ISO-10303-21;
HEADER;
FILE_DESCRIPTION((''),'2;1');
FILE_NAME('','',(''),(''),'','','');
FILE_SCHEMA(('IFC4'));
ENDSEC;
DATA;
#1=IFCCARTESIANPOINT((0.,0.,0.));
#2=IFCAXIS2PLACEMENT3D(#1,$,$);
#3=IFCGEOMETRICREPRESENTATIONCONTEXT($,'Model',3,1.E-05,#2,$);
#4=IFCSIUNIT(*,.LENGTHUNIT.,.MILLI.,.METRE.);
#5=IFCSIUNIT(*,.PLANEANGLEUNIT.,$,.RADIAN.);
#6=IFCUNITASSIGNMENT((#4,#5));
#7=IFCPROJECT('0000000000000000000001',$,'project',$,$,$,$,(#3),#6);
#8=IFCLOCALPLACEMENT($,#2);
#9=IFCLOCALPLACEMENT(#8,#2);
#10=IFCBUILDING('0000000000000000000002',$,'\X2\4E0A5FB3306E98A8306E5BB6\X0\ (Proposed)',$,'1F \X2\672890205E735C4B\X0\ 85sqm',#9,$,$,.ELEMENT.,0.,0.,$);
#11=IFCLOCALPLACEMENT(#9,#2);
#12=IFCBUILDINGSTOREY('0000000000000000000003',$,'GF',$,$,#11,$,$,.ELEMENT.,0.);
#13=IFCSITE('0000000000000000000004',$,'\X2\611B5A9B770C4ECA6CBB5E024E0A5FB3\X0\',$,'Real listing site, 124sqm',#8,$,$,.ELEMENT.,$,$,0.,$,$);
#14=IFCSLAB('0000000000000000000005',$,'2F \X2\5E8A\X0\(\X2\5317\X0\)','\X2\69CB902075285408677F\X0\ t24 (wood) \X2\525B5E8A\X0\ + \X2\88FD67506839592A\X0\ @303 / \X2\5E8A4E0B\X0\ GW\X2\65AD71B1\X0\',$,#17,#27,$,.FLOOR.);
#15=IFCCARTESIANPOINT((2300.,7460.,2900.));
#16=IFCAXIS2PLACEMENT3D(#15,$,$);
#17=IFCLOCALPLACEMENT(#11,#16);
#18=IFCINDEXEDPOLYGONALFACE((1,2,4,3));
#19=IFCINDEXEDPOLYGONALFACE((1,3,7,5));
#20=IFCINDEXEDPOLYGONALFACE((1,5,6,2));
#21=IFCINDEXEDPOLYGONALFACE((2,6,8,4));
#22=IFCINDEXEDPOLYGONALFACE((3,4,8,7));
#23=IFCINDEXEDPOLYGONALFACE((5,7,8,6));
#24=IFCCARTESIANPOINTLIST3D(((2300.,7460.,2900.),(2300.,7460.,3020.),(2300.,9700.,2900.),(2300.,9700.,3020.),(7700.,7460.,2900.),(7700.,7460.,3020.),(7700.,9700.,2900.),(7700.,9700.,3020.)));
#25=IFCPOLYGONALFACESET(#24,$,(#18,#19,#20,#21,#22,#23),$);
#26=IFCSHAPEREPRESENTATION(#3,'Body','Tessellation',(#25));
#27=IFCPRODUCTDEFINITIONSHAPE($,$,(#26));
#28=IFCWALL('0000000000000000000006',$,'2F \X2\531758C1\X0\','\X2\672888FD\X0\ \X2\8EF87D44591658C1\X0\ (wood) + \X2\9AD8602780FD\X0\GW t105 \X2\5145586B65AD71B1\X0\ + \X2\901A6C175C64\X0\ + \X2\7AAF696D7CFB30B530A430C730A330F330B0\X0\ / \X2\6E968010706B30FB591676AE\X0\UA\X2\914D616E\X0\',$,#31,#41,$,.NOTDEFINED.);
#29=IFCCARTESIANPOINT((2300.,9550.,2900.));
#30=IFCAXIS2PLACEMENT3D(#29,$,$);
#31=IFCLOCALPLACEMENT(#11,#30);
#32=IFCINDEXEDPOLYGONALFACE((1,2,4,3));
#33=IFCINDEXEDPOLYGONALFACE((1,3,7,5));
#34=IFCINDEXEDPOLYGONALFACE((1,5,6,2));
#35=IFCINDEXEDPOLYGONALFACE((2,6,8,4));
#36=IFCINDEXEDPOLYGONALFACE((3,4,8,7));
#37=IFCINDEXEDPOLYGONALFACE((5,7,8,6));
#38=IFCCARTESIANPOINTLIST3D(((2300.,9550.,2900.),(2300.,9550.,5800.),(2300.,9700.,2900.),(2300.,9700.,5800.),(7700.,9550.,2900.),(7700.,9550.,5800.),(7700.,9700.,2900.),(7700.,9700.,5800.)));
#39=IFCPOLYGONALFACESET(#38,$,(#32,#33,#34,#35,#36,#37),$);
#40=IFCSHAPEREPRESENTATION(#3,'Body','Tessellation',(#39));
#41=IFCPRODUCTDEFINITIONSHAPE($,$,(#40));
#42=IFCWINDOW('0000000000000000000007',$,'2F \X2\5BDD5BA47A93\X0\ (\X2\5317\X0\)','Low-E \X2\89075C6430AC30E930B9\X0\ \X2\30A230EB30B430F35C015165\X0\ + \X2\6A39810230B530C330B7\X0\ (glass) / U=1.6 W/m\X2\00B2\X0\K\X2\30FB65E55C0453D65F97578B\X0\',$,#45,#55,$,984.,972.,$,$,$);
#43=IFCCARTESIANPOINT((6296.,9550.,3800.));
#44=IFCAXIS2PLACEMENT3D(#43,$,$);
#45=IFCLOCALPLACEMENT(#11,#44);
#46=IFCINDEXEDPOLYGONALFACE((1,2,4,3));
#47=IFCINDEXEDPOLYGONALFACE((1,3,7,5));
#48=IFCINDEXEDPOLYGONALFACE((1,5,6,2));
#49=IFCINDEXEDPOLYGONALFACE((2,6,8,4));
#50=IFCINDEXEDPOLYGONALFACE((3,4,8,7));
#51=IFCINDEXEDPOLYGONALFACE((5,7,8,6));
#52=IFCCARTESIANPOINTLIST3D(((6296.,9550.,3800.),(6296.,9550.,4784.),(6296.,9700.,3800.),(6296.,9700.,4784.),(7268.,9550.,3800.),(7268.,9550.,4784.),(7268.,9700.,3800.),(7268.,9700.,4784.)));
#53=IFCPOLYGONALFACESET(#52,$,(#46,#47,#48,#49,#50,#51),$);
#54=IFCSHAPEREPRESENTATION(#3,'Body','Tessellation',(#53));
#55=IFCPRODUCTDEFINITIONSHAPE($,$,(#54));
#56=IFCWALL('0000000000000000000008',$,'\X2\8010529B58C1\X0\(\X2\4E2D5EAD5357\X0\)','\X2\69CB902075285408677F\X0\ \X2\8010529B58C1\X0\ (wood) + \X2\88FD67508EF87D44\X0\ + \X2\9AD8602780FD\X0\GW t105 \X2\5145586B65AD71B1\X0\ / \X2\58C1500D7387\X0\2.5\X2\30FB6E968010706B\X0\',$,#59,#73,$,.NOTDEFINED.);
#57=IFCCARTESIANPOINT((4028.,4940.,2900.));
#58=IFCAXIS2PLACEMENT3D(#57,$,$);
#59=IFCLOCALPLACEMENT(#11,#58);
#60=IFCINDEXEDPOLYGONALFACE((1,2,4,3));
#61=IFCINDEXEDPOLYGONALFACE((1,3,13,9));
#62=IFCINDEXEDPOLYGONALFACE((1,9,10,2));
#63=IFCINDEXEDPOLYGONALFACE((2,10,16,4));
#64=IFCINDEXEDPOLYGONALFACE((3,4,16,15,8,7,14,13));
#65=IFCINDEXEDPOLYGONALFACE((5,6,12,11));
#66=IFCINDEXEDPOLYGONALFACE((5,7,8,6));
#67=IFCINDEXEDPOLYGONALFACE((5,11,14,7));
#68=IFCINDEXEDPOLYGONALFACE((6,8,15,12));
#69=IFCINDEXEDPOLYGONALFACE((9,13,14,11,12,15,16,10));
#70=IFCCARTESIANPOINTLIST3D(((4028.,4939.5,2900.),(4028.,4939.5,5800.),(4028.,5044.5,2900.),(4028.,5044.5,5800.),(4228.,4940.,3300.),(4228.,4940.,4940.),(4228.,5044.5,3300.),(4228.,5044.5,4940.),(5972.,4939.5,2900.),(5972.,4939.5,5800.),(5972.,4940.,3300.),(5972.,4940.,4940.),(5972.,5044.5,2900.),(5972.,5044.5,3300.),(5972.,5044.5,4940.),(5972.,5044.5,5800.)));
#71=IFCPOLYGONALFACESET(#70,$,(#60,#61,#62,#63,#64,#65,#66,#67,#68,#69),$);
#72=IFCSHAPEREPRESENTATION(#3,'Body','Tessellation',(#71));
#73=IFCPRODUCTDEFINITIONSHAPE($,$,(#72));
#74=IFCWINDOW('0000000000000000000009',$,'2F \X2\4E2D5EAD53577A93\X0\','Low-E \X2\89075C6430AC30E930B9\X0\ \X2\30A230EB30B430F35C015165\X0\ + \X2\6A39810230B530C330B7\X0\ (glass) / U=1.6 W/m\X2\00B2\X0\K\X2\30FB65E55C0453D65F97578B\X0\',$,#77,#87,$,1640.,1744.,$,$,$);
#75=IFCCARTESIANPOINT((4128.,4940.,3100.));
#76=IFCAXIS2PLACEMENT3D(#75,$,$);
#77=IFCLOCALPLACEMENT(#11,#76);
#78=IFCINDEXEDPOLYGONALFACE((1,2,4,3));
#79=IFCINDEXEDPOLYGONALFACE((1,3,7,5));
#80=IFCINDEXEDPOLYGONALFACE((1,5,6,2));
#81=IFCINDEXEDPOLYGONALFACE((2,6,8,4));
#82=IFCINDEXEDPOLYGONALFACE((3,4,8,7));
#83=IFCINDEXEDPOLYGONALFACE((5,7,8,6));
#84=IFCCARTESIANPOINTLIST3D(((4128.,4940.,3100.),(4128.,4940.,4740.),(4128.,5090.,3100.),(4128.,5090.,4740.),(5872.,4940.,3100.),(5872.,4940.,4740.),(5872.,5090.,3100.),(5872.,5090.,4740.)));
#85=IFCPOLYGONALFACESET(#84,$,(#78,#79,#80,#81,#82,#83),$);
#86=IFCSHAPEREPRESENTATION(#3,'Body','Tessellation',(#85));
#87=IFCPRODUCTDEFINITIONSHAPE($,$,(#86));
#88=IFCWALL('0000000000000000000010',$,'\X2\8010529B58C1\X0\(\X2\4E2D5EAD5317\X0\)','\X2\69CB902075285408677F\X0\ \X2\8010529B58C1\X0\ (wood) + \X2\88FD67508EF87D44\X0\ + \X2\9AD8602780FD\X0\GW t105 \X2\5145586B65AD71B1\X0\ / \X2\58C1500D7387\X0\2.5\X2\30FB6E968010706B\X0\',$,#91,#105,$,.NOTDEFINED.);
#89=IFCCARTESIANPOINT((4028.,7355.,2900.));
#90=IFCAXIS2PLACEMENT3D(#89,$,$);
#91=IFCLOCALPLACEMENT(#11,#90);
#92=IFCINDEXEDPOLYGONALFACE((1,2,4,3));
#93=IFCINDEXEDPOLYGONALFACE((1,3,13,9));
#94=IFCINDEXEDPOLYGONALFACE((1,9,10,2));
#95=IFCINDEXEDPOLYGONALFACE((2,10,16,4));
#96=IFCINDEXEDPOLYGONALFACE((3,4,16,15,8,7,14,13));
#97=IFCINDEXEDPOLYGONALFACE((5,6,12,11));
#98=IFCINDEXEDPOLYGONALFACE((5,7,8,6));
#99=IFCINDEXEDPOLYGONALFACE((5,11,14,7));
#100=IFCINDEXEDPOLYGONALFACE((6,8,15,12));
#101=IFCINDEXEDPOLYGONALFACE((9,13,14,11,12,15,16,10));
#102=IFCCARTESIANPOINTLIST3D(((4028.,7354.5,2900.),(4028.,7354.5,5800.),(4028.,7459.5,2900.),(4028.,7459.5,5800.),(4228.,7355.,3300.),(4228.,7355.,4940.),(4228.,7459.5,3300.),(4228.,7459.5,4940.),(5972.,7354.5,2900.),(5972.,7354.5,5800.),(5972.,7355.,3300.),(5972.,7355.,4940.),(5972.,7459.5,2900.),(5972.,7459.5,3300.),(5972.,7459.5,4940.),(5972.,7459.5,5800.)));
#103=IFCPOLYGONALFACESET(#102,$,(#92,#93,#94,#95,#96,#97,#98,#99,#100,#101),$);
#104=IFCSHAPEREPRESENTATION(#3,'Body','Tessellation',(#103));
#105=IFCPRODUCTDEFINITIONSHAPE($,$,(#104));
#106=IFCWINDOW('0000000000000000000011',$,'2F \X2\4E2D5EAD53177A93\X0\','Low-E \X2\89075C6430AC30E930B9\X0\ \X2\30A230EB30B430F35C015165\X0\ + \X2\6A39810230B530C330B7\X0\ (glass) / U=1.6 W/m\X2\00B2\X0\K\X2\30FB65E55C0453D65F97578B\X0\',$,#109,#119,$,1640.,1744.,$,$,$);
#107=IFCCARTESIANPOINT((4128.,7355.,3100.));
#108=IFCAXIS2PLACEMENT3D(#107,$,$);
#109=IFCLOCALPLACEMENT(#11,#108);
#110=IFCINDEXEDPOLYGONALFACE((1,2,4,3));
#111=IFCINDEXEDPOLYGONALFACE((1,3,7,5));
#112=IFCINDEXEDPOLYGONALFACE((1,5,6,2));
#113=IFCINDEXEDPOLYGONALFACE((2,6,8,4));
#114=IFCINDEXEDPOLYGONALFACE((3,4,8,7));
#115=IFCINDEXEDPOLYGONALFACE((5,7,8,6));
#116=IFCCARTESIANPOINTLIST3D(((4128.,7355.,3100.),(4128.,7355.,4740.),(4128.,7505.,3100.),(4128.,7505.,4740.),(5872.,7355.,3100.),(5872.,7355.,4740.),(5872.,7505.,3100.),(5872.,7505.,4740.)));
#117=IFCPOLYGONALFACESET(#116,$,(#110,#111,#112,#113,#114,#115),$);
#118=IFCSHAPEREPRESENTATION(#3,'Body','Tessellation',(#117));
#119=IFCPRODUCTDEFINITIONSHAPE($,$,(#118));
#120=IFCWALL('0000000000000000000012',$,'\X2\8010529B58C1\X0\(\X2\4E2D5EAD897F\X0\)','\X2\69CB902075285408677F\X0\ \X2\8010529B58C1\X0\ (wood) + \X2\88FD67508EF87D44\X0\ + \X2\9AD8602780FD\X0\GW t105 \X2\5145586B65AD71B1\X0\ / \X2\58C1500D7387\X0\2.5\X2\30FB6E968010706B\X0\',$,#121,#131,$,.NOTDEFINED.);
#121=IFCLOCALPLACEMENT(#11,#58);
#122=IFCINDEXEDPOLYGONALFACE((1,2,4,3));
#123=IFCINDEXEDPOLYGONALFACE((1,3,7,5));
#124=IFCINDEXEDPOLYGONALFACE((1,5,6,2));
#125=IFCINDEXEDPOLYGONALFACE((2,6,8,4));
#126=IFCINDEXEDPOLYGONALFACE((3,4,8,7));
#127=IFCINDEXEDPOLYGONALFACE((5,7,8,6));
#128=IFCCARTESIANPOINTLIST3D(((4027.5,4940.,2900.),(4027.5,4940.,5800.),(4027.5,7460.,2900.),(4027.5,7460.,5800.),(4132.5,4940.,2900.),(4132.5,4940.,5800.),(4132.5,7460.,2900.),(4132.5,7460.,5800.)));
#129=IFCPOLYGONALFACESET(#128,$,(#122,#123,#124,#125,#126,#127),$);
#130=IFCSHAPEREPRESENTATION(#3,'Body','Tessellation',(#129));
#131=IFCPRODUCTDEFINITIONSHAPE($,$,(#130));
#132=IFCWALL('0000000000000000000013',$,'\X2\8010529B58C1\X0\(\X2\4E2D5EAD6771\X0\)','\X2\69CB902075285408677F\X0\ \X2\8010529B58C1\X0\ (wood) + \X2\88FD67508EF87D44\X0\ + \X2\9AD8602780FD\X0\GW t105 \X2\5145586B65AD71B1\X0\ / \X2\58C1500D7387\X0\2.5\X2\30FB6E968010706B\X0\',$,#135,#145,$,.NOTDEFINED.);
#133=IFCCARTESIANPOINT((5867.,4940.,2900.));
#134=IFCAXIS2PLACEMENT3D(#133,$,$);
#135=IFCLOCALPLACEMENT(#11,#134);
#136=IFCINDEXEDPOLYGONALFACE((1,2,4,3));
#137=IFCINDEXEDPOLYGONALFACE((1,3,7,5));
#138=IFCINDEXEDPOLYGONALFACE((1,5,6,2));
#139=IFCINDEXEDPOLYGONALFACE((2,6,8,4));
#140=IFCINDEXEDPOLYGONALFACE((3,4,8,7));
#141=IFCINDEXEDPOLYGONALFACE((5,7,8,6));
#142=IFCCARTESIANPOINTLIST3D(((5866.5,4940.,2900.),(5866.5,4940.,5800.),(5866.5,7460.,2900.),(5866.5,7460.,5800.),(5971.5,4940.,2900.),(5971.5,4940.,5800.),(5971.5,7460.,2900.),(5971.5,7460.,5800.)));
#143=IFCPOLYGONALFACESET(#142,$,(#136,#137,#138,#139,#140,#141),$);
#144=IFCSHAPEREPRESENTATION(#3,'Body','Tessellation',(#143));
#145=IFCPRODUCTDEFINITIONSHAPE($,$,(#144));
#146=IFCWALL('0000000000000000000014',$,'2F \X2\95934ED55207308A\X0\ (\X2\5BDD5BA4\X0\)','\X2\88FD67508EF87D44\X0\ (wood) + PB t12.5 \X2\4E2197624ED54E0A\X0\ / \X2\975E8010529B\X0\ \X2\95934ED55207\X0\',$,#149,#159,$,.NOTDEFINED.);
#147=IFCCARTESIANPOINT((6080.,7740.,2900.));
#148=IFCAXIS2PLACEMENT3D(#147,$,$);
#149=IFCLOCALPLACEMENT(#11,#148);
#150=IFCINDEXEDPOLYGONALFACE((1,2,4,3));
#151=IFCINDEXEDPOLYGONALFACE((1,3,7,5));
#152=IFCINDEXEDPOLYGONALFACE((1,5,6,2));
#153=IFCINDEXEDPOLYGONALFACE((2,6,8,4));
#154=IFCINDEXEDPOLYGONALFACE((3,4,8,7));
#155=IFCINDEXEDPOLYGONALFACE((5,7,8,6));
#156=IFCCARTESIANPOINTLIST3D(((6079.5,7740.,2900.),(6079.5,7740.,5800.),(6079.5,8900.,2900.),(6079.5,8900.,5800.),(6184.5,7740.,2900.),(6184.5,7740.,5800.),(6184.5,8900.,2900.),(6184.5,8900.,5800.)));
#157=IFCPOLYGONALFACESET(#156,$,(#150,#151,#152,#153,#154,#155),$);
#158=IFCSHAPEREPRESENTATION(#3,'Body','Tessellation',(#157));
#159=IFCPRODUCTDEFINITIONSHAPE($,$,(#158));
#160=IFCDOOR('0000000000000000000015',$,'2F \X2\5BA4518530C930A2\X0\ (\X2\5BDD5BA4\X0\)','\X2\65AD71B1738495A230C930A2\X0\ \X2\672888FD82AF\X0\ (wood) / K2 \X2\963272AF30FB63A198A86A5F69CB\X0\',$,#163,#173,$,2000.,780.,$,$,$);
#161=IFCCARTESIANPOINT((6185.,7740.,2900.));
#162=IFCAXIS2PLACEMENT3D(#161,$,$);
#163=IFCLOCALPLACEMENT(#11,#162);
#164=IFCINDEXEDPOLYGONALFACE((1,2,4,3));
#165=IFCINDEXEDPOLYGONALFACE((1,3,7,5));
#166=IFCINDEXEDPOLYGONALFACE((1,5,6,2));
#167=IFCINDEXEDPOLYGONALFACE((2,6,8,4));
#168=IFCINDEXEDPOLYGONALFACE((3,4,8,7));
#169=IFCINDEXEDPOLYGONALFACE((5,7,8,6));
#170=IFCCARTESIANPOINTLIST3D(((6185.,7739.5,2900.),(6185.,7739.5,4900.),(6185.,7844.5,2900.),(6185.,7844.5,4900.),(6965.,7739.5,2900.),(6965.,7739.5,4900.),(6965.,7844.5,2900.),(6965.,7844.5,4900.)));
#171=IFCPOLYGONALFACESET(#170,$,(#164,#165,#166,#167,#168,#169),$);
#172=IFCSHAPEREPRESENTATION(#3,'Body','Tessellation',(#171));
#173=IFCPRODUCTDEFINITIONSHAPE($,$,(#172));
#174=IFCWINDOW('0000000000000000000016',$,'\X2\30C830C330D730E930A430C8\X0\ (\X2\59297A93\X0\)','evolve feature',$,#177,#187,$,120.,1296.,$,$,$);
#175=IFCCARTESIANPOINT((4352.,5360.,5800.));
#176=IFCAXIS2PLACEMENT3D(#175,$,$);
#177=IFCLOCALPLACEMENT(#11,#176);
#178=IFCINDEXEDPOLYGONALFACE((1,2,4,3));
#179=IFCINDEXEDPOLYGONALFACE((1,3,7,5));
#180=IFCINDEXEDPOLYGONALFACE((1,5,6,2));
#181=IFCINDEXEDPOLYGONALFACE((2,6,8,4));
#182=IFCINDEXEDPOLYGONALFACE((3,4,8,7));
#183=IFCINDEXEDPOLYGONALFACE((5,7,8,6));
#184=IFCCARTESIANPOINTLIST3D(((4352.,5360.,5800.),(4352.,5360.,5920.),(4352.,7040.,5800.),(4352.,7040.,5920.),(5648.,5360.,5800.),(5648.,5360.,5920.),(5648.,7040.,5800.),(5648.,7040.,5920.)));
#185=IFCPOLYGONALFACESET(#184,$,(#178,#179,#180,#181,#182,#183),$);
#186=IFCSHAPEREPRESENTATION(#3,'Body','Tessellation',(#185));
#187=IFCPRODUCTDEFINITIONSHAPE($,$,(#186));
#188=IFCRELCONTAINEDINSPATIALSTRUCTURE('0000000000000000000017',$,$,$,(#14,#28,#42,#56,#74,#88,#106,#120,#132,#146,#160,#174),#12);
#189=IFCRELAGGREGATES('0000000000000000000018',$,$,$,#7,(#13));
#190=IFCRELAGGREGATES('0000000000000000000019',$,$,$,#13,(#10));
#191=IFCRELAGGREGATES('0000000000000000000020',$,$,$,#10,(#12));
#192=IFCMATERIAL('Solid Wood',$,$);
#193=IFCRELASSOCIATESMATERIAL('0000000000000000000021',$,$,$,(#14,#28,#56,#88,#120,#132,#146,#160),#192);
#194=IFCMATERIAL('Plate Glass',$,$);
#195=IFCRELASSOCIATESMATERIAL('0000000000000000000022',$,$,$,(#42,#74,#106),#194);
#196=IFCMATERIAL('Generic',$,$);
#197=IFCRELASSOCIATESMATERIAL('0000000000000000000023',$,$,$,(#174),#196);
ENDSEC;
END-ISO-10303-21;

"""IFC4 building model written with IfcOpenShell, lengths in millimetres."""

from ifc_helpers import new_model, si_unit, frame, frame_2d, origin, place, context, project, spatial, rectangle, extrude, material, element, fill, save


model = new_model("IFC4")

# Units and contexts
model_context = context("Model", 3, precision=1e-05, world=origin())
ifc_project = project(units=[si_unit("LENGTHUNIT", "METRE", prefix="MILLI"), si_unit("PLANEANGLEUNIT", "RADIAN")], contexts=[model_context])

# Site, building, storey
site_placement = place(None, origin())
site = spatial("IfcSite", under=ifc_project, at=site_placement, Name="愛媛県今治市上徳", ObjectType="Real listing site, 124sqm", CompositionType="ELEMENT", RefElevation=0.0)
building_placement = place(site_placement, origin())
building = spatial("IfcBuilding", under=site, at=building_placement, Name="上徳の風の家 (Proposed)", ObjectType="1F 木造平屋 85sqm", CompositionType="ELEMENT", ElevationOfRefHeight=0.0, ElevationOfTerrain=0.0)
storey_placement = place(building_placement, origin())
storey = spatial("IfcBuildingStorey", under=building, at=storey_placement, Name="GF", CompositionType="ELEMENT", Elevation=0.0)

# Slab
ifc_material_1 = material(Name="Solid Wood")
slab_placement = place(storey_placement, frame((2300.0, 7460.0, 2900.0)))
element("IfcSlab", 1, at=slab_placement, inside=storey, material=ifc_material_1, Name="2F 床(北)", Description="構造用合板 t24 (wood) 剛床 + 製材根太 @303 / 床下 GW断熱", PredefinedType="FLOOR", context=model_context, shape_type="SweptSolid", body=[
    extrude(rectangle(XDim=5400.0, YDim=2240.0, at=frame_2d((2700.0, 1120.0))), frame((2300.0, 7460.0, 2900.0)), (0.0, 0.0, 1.0), 120.0),
])

# Walls, openings, windows
wall_1_placement = place(storey_placement, frame((2300.0, 9550.0, 2900.0)))
wall_1 = element("IfcWall", 2, at=wall_1_placement, inside=storey, material=ifc_material_1, Name="2F 北壁", Description="木製 軸組外壁 (wood) + 高性能GW t105 充填断熱 + 通気層 + 窯業系サイディング / 準耐火・外皮UA配慮", PredefinedType="NOTDEFINED", context=model_context, shape_type="SweptSolid", body=[
    extrude(rectangle(XDim=5400.0, YDim=150.0, at=frame_2d((2700.0, 75.0))), frame((2300.0, 9550.0, 2900.0)), (0.0, 0.0, 1.0), 2900.0),
])
opening_1_placement = place(storey_placement, frame((6296.0, 9550.0, 3800.0)))
opening_1 = element("IfcOpeningElement", 3, at=opening_1_placement, cuts=wall_1, PredefinedType="NOTDEFINED", context=model_context, shape_type="SweptSolid", body=[
    extrude(rectangle(XDim=972.0, YDim=150.0, at=frame_2d((486.0, 75.0))), frame((6296.0, 9550.0, 3800.0)), (0.0, 0.0, 1.0), 984.0),
])
ifc_material_2 = material(Name="Plate Glass")
window_1_placement = place(storey_placement, frame((6296.0, 9550.0, 3800.0)))
window_1 = element("IfcWindow", 4, at=window_1_placement, inside=storey, material=ifc_material_2, Name="2F 寝室窓 (北)", Description="Low-E 複層ガラス アルゴン封入 + 樹脂サッシ (glass) / U=1.6 W/m²K・日射取得型", OverallHeight=984.0, OverallWidth=972.0, context=model_context, shape_type="SweptSolid", body=[
    extrude(rectangle(XDim=972.0, YDim=150.0, at=frame_2d((486.0, 75.0))), frame((6296.0, 9550.0, 3800.0)), (0.0, 0.0, 1.0), 984.0),
])
fill(opening_1, window_1)
wall_2_placement = place(storey_placement, frame((4028.0, 4940.0, 2900.0)))
wall_2 = element("IfcWall", 5, at=wall_2_placement, inside=storey, material=ifc_material_1, Name="耐力壁(中庭南)", Description="構造用合板 耐力壁 (wood) + 製材軸組 + 高性能GW t105 充填断熱 / 壁倍率2.5・準耐火", PredefinedType="NOTDEFINED", context=model_context, shape_type="SweptSolid", body=[
    extrude(rectangle(XDim=1944.0, YDim=105.0, at=frame_2d((972.0, 52.0))), frame((4028.0, 4940.0, 2900.0)), (0.0, 0.0, 1.0), 2900.0),
])
opening_2_placement = place(storey_placement, frame((4128.0, 4940.0, 3100.0)))
opening_2 = element("IfcOpeningElement", 6, at=opening_2_placement, cuts=wall_2, PredefinedType="NOTDEFINED", context=model_context, shape_type="SweptSolid", body=[
    extrude(rectangle(XDim=1744.0, YDim=150.0, at=frame_2d((872.0, 75.0))), frame((4128.0, 4940.0, 3100.0)), (0.0, 0.0, 1.0), 1640.0),
])
window_2_placement = place(storey_placement, frame((4128.0, 4940.0, 3100.0)))
window_2 = element("IfcWindow", 7, at=window_2_placement, inside=storey, material=ifc_material_2, Name="2F 中庭南窓", Description="Low-E 複層ガラス アルゴン封入 + 樹脂サッシ (glass) / U=1.6 W/m²K・日射取得型", OverallHeight=1640.0, OverallWidth=1744.0, context=model_context, shape_type="SweptSolid", body=[
    extrude(rectangle(XDim=1744.0, YDim=150.0, at=frame_2d((872.0, 75.0))), frame((4128.0, 4940.0, 3100.0)), (0.0, 0.0, 1.0), 1640.0),
])
fill(opening_2, window_2)
wall_3_placement = place(storey_placement, frame((4028.0, 7355.0, 2900.0)))
wall_3 = element("IfcWall", 8, at=wall_3_placement, inside=storey, material=ifc_material_1, Name="耐力壁(中庭北)", Description="構造用合板 耐力壁 (wood) + 製材軸組 + 高性能GW t105 充填断熱 / 壁倍率2.5・準耐火", PredefinedType="NOTDEFINED", context=model_context, shape_type="SweptSolid", body=[
    extrude(rectangle(XDim=1944.0, YDim=105.0, at=frame_2d((972.0, 52.0))), frame((4028.0, 7355.0, 2900.0)), (0.0, 0.0, 1.0), 2900.0),
])
opening_3_placement = place(storey_placement, frame((4128.0, 7355.0, 3100.0)))
opening_3 = element("IfcOpeningElement", 9, at=opening_3_placement, cuts=wall_3, PredefinedType="NOTDEFINED", context=model_context, shape_type="SweptSolid", body=[
    extrude(rectangle(XDim=1744.0, YDim=150.0, at=frame_2d((872.0, 75.0))), frame((4128.0, 7355.0, 3100.0)), (0.0, 0.0, 1.0), 1640.0),
])
window_3_placement = place(storey_placement, frame((4128.0, 7355.0, 3100.0)))
window_3 = element("IfcWindow", 10, at=window_3_placement, inside=storey, material=ifc_material_2, Name="2F 中庭北窓", Description="Low-E 複層ガラス アルゴン封入 + 樹脂サッシ (glass) / U=1.6 W/m²K・日射取得型", OverallHeight=1640.0, OverallWidth=1744.0, context=model_context, shape_type="SweptSolid", body=[
    extrude(rectangle(XDim=1744.0, YDim=150.0, at=frame_2d((872.0, 75.0))), frame((4128.0, 7355.0, 3100.0)), (0.0, 0.0, 1.0), 1640.0),
])
fill(opening_3, window_3)

# Walls
wall_4_placement = place(storey_placement, frame((4028.0, 4940.0, 2900.0)))
element("IfcWall", 11, at=wall_4_placement, inside=storey, material=ifc_material_1, Name="耐力壁(中庭西)", Description="構造用合板 耐力壁 (wood) + 製材軸組 + 高性能GW t105 充填断熱 / 壁倍率2.5・準耐火", PredefinedType="NOTDEFINED", context=model_context, shape_type="SweptSolid", body=[
    extrude(rectangle(XDim=105.0, YDim=2520.0, at=frame_2d((52.0, 1260.0))), frame((4028.0, 4940.0, 2900.0)), (0.0, 0.0, 1.0), 2900.0),
])
wall_5_placement = place(storey_placement, frame((5867.0, 4940.0, 2900.0)))
element("IfcWall", 12, at=wall_5_placement, inside=storey, material=ifc_material_1, Name="耐力壁(中庭東)", Description="構造用合板 耐力壁 (wood) + 製材軸組 + 高性能GW t105 充填断熱 / 壁倍率2.5・準耐火", PredefinedType="NOTDEFINED", context=model_context, shape_type="SweptSolid", body=[
    extrude(rectangle(XDim=105.0, YDim=2520.0, at=frame_2d((52.0, 1260.0))), frame((5867.0, 4940.0, 2900.0)), (0.0, 0.0, 1.0), 2900.0),
])
wall_6_placement = place(storey_placement, frame((6080.0, 7740.0, 2900.0)))
element("IfcWall", 13, at=wall_6_placement, inside=storey, material=ifc_material_1, Name="2F 間仕切り (寝室)", Description="製材軸組 (wood) + PB t12.5 両面仕上 / 非耐力 間仕切", PredefinedType="NOTDEFINED", context=model_context, shape_type="SweptSolid", body=[
    extrude(rectangle(XDim=105.0, YDim=1160.0, at=frame_2d((52.0, 580.0))), frame((6080.0, 7740.0, 2900.0)), (0.0, 0.0, 1.0), 2900.0),
])

# Door
door_placement = place(storey_placement, frame((6185.0, 7740.0, 2900.0)))
element("IfcDoor", 14, at=door_placement, inside=storey, material=ifc_material_1, Name="2F 室内ドア (寝室)", Description="断熱玄関ドア 木製芯 (wood) / K2 防犯・採風機構", OverallHeight=2000.0, OverallWidth=780.0, context=model_context, shape_type="SweptSolid", body=[
    extrude(rectangle(XDim=780.0, YDim=105.0, at=frame_2d((390.0, 52.0))), frame((6185.0, 7740.0, 2900.0)), (0.0, 0.0, 1.0), 2000.0),
])

# Window
ifc_material_3 = material(Name="Generic")
window_4_placement = place(storey_placement, frame((4352.0, 5360.0, 5800.0)))
element("IfcWindow", 15, at=window_4_placement, inside=storey, material=ifc_material_3, Name="トップライト (天窓)", Description="evolve feature", OverallHeight=120.0, OverallWidth=1296.0, context=model_context, shape_type="SweptSolid", body=[
    extrude(rectangle(XDim=1296.0, YDim=1680.0, at=frame_2d((648.0, 840.0))), frame((4352.0, 5360.0, 5800.0)), (0.0, 0.0, 1.0), 120.0),
])

save(model, "model.ifc")
